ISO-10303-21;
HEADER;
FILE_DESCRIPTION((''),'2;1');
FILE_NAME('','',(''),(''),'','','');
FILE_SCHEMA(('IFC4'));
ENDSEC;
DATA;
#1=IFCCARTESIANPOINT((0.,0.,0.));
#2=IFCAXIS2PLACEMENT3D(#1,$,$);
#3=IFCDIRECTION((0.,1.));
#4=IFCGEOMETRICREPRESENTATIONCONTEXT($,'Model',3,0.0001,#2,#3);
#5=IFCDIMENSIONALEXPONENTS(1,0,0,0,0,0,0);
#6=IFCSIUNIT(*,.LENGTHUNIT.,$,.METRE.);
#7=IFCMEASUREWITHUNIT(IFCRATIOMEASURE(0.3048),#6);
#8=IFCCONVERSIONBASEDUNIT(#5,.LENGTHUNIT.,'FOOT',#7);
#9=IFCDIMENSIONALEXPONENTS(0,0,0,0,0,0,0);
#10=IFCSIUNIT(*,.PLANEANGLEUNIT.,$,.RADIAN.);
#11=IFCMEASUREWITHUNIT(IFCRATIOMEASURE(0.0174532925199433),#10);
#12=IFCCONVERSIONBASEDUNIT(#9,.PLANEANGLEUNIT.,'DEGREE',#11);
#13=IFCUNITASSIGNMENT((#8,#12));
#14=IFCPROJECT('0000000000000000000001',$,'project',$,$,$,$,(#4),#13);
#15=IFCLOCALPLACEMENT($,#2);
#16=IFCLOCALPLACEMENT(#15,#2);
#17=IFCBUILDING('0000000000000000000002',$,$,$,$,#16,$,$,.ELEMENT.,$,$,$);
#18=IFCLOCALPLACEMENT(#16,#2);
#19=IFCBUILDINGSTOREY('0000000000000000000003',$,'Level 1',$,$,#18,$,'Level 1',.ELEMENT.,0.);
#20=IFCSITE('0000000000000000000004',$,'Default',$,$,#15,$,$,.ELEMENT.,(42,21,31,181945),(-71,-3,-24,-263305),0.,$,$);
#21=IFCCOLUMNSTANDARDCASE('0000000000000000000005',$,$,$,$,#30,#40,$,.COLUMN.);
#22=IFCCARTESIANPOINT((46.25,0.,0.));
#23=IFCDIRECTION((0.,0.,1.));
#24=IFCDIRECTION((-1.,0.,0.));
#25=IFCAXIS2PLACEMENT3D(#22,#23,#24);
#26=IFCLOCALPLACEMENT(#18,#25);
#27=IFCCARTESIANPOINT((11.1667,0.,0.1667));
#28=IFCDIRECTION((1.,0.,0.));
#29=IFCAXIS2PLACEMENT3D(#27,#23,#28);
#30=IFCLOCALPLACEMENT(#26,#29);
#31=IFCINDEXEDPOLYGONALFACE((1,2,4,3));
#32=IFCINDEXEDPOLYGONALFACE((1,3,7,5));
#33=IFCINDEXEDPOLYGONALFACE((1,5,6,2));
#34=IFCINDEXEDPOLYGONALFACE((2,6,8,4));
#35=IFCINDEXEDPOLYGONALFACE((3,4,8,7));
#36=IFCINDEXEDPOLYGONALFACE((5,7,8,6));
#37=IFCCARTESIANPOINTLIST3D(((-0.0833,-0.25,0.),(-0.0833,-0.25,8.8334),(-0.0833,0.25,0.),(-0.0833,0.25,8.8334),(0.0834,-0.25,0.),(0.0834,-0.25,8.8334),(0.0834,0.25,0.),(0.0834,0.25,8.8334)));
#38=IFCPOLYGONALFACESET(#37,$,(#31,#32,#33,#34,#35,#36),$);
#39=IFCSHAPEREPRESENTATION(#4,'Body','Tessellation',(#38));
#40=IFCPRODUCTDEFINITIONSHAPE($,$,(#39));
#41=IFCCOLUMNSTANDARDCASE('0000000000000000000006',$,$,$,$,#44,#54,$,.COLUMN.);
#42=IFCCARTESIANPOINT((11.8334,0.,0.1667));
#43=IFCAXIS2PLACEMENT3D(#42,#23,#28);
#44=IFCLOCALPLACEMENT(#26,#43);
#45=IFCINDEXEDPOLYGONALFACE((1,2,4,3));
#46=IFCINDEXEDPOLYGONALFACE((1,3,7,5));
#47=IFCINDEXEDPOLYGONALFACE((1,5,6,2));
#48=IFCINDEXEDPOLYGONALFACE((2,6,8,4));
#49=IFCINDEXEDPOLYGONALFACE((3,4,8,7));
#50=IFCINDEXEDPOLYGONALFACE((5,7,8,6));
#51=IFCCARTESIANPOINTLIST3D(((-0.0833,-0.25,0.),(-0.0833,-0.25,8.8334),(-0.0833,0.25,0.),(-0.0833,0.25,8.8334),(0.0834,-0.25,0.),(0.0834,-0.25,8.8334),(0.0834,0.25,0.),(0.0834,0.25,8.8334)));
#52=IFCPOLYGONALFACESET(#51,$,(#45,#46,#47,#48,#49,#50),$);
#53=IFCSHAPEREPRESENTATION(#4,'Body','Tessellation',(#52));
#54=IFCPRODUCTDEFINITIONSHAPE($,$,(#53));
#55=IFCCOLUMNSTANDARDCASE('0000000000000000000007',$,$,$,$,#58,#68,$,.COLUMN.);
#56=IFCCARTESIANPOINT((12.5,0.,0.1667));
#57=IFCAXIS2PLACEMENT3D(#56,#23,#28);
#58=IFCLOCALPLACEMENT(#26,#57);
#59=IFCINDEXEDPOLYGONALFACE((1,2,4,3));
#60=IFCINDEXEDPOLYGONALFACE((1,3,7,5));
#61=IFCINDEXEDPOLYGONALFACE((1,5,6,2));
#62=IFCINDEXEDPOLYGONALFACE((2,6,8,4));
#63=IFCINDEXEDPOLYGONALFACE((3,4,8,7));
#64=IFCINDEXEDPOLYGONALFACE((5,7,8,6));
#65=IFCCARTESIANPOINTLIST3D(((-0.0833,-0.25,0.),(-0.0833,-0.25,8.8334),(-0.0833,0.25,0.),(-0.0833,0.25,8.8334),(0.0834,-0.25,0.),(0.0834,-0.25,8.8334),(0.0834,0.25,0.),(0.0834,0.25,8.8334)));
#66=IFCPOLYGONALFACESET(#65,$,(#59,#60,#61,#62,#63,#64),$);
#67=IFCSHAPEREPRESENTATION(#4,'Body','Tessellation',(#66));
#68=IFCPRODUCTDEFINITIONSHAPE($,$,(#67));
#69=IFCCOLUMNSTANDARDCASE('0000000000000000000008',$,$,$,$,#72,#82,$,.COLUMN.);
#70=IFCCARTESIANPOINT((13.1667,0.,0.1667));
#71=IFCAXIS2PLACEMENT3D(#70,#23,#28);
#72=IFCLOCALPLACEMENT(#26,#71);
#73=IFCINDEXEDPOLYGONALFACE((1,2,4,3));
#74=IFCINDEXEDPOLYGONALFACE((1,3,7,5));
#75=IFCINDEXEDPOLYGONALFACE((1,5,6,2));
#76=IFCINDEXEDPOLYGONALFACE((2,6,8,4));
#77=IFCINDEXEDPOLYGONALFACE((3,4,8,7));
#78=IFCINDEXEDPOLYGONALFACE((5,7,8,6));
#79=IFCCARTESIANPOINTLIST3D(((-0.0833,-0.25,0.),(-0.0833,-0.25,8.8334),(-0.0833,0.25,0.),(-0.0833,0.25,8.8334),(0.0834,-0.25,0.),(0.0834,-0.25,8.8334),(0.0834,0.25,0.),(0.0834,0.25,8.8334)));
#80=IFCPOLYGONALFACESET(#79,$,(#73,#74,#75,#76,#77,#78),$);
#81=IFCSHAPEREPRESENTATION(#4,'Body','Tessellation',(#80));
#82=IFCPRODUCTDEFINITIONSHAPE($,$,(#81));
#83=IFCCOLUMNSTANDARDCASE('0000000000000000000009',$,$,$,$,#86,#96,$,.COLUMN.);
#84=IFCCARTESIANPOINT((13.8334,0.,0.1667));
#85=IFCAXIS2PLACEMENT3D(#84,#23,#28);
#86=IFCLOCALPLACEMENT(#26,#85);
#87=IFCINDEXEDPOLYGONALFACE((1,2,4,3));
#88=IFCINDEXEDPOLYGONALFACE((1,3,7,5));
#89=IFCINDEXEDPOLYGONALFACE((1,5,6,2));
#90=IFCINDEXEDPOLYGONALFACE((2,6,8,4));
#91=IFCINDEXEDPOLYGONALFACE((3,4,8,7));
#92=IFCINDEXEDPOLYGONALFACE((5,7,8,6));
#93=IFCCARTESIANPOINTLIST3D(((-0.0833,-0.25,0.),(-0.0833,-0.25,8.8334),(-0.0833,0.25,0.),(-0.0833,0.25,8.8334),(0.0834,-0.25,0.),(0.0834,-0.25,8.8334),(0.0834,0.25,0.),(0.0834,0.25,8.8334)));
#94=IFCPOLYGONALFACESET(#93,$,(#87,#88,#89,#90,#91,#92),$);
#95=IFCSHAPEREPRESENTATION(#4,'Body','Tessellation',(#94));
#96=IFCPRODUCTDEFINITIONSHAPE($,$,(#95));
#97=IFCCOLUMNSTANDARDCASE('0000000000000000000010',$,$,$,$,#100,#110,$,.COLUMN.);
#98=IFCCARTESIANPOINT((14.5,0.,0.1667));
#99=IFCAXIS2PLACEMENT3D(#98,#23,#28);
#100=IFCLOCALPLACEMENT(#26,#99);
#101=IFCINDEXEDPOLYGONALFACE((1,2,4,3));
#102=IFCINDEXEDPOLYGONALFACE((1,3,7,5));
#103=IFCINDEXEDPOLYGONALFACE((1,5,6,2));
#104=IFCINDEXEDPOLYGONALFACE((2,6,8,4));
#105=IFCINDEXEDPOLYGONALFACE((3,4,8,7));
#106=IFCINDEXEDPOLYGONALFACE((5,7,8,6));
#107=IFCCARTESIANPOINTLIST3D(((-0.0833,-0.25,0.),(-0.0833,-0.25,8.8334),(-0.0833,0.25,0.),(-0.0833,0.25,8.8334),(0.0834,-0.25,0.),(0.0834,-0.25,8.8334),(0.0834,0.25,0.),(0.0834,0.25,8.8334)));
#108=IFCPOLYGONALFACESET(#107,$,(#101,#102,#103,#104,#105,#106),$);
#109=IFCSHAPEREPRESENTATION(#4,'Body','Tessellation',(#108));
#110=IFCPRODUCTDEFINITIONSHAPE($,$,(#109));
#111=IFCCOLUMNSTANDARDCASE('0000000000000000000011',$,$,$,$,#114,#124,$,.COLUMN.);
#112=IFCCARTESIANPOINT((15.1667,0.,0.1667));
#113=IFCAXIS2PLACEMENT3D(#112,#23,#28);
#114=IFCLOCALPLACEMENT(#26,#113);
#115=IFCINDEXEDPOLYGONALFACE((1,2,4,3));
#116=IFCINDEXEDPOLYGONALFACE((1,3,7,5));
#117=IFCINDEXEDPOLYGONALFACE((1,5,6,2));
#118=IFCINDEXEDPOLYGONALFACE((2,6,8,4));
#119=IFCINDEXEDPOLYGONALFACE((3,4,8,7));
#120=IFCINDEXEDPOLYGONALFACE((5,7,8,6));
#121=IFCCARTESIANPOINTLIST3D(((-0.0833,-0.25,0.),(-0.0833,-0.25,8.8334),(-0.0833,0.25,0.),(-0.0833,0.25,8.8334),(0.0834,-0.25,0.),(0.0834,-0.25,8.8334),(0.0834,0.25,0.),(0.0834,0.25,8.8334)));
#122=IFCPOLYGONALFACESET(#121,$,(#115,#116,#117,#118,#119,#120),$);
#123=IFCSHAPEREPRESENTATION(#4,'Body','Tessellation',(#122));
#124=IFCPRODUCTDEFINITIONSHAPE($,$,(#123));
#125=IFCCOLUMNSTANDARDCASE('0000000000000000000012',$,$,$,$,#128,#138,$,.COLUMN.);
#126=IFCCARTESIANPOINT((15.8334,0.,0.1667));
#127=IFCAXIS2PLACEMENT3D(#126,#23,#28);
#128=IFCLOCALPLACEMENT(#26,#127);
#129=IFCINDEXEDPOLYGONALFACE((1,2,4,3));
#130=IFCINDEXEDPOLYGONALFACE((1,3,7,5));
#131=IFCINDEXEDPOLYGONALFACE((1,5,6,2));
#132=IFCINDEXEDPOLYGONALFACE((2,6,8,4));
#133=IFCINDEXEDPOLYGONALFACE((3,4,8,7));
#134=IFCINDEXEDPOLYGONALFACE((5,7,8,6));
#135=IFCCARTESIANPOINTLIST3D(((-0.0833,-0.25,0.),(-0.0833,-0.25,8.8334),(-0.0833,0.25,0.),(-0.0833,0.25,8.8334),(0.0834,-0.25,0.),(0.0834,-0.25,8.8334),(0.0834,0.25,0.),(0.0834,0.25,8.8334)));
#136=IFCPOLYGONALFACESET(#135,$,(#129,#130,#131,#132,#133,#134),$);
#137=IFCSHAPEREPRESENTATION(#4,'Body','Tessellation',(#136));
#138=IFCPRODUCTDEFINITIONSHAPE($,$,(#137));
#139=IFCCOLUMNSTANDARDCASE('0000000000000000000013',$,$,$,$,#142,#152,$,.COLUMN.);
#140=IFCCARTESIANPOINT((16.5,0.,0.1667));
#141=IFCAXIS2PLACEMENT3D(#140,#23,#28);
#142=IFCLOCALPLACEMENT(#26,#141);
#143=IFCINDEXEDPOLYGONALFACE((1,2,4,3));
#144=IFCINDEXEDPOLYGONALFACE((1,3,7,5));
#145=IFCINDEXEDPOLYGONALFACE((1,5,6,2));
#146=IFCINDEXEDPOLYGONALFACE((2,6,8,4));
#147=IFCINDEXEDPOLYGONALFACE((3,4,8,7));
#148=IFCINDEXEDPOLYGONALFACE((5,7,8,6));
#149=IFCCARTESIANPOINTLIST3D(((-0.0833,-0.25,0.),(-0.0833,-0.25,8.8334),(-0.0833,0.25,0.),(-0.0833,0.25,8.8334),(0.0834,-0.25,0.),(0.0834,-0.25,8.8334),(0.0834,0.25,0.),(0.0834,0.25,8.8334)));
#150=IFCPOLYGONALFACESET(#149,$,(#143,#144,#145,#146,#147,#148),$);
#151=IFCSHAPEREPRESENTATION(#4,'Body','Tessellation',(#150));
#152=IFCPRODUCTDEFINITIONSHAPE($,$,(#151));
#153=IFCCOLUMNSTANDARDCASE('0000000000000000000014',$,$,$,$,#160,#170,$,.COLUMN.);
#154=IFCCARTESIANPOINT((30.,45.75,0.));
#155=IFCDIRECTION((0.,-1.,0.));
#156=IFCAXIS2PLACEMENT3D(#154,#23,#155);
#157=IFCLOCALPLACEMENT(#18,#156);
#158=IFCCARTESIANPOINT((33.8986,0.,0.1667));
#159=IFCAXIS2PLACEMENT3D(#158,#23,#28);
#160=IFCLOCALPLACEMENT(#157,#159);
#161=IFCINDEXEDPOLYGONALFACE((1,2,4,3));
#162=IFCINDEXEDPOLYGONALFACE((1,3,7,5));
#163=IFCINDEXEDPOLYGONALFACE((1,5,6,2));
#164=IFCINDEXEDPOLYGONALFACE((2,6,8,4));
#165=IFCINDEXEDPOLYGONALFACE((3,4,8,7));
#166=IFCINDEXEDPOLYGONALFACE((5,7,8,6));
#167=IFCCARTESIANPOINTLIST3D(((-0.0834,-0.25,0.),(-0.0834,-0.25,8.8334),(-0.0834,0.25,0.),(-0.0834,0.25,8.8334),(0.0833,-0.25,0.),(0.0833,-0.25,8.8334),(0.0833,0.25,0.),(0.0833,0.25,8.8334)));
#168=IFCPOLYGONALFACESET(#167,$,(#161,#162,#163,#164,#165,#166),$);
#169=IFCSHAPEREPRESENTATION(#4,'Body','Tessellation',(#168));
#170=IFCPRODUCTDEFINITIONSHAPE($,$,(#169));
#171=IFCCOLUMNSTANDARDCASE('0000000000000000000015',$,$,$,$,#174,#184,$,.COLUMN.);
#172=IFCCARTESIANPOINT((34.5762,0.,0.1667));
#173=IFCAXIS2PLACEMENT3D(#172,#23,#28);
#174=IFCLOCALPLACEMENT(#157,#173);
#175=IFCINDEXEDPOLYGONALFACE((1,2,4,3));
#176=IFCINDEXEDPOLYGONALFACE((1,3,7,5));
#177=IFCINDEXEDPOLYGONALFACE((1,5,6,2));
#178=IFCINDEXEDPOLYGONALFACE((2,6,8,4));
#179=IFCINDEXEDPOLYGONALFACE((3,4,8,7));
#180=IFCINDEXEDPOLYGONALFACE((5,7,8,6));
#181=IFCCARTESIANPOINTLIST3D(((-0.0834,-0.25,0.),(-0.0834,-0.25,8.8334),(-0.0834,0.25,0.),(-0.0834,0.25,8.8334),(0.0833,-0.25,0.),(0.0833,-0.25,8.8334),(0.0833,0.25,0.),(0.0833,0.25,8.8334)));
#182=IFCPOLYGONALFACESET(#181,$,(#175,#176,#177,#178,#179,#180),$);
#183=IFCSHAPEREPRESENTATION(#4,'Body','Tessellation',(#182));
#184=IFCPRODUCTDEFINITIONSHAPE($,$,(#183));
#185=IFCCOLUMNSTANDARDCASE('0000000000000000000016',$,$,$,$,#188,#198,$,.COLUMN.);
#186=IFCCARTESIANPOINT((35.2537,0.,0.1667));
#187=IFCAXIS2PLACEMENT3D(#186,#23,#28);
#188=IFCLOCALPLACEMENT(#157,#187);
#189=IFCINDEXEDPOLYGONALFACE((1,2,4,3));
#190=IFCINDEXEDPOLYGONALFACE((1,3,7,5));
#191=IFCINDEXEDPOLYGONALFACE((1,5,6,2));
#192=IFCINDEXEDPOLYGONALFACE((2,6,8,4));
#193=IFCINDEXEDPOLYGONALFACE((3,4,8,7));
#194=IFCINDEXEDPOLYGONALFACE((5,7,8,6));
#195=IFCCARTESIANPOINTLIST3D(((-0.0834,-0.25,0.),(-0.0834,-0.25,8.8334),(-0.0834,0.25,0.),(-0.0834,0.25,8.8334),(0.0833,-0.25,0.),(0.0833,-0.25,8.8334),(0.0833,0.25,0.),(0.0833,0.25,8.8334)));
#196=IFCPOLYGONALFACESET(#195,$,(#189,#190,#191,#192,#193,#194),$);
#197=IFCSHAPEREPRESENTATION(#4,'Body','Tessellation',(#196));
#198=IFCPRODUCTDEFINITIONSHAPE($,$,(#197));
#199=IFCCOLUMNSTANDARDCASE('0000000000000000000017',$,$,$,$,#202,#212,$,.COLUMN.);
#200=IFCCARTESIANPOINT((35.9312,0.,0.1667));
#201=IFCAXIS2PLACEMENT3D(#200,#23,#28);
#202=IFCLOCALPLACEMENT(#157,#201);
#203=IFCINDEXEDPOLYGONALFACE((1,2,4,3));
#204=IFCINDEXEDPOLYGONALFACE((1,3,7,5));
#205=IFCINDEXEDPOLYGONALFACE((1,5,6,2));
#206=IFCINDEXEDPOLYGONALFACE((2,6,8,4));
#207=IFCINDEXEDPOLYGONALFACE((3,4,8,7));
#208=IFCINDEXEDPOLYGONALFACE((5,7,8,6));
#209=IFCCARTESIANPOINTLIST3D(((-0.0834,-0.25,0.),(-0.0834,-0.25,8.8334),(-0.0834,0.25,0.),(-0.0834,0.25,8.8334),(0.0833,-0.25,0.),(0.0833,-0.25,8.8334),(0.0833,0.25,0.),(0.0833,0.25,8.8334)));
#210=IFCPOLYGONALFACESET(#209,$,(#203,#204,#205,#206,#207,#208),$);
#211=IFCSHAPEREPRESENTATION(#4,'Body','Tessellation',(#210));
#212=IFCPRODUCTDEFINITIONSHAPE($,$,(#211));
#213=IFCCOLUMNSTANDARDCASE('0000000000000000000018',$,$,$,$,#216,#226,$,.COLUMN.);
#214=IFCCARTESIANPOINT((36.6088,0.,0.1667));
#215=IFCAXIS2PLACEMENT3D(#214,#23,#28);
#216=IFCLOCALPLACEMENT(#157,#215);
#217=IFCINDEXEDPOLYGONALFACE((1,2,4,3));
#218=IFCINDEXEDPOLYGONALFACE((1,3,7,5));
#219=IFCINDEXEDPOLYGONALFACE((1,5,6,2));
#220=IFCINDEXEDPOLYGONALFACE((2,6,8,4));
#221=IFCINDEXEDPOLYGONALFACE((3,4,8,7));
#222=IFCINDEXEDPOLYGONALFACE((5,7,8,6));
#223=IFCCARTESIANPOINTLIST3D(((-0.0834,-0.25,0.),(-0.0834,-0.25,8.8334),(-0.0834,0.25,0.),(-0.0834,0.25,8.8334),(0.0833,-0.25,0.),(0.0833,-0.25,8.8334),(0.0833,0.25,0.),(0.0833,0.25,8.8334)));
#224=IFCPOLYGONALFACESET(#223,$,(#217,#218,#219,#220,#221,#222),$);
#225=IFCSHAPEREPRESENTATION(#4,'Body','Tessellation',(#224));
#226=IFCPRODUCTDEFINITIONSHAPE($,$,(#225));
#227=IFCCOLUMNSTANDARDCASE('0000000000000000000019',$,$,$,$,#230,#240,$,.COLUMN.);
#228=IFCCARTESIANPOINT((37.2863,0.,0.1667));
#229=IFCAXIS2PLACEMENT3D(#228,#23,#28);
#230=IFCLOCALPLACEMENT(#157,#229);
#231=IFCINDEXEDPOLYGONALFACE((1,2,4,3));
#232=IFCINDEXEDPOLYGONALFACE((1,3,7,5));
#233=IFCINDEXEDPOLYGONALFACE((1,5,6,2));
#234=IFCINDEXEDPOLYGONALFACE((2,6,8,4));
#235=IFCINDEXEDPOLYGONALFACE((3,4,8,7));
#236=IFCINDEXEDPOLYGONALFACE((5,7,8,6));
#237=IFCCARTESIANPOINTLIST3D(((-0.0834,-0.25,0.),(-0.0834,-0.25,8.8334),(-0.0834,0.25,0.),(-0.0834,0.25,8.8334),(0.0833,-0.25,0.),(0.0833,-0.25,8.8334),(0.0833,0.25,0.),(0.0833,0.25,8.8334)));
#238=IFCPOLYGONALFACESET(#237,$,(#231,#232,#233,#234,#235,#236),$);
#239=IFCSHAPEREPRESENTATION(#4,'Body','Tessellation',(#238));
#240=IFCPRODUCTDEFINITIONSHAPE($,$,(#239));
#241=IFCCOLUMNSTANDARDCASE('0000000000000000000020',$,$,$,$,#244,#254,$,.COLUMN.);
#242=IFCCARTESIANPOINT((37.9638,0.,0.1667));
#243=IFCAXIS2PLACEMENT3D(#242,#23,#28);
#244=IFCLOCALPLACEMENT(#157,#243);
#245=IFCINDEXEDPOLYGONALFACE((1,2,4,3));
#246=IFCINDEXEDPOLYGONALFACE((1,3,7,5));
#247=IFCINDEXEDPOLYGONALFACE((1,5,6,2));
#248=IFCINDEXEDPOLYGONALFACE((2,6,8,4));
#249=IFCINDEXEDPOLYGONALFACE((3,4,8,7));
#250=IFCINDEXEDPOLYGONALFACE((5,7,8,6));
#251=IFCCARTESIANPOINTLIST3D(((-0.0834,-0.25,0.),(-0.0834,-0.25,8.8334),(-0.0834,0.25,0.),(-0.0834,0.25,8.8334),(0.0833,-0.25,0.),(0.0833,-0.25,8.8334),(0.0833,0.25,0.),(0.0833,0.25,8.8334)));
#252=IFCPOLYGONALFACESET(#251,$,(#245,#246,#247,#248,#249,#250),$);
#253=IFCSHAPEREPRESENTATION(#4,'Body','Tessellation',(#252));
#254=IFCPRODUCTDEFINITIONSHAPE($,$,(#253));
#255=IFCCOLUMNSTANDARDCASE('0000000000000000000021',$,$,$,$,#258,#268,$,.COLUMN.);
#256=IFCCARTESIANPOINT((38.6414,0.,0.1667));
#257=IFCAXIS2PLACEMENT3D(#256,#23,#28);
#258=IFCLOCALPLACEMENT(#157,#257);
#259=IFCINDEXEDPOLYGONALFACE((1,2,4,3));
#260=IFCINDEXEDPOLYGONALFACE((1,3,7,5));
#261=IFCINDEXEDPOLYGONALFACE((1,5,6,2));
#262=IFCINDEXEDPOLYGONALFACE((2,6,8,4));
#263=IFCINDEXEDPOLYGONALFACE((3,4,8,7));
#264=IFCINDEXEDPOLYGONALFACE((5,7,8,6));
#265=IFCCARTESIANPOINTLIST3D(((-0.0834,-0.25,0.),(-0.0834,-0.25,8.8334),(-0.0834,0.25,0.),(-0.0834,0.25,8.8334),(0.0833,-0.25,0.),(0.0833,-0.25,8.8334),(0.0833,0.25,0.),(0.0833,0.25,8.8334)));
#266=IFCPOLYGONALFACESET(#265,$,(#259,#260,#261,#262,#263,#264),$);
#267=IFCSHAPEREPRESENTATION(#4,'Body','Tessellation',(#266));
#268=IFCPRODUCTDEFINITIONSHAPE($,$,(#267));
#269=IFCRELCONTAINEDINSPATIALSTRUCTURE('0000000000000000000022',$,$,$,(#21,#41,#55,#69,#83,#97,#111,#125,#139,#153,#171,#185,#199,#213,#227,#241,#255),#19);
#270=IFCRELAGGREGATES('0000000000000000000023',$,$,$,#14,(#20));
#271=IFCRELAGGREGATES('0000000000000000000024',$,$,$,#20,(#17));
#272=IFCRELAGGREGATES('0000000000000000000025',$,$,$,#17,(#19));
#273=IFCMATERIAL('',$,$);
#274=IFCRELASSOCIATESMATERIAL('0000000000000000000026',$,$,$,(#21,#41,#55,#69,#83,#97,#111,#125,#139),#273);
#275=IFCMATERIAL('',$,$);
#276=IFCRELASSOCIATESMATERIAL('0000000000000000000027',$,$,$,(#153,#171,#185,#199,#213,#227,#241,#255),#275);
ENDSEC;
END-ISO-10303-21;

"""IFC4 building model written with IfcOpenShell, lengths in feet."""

from ifc_helpers import new_model, entity, si_unit, converted_unit, direction, frame, origin, place, context, project, spatial, rectangle, extrude, material, element, save


model = new_model("IFC4")

# Units and contexts
model_context = context("Model", 3, precision=0.0001, world=origin(), true_north=direction((0.0, 1.0)))
ifc_project = project(units=[converted_unit("LENGTHUNIT", "FOOT", entity("IfcRatioMeasure", 0.3048), si_unit("LENGTHUNIT", "METRE"), dimensions=[1, 0, 0, 0, 0, 0, 0]), converted_unit("PLANEANGLEUNIT", "DEGREE", entity("IfcRatioMeasure", 0.0174532925199433), si_unit("PLANEANGLEUNIT", "RADIAN"), dimensions=[0, 0, 0, 0, 0, 0, 0])], contexts=[model_context])

# Site, building, storey
site_placement = place(None, origin())
site = spatial("IfcSite", under=ifc_project, at=site_placement, Name="Default", CompositionType="ELEMENT", RefLatitude=(42, 21, 31, 181945), RefLongitude=(-71, -3, -24, -263305), RefElevation=0.0)
building_placement = place(site_placement, origin())
building = spatial("IfcBuilding", under=site, at=building_placement, CompositionType="ELEMENT")
storey_placement = place(building_placement, origin())
storey = spatial("IfcBuildingStorey", under=building, at=storey_placement, Name="Level 1", LongName="Level 1", CompositionType="ELEMENT", Elevation=0.0)

# Columns
ifc_material_1 = material(Name="")
placement_1 = place(storey_placement, frame((46.25, 0.0, 0.0), z_axis=(0.0, 0.0, 1.0), x_axis=(-1.0, 0.0, 0.0)))
for number, where, z_axis, x_axis in (
    (1, (11.1667, 0.0, 0.1667), (0.0, 0.0, 1.0), (1.0, 0.0, 0.0)),
    (2, (11.8334, 0.0, 0.1667), (0.0, 0.0, 1.0), (1.0, 0.0, 0.0)),
    (3, (12.5, 0.0, 0.1667), (0.0, 0.0, 1.0), (1.0, 0.0, 0.0)),
    (4, (13.1667, 0.0, 0.1667), (0.0, 0.0, 1.0), (1.0, 0.0, 0.0)),
    (5, (13.8334, 0.0, 0.1667), (0.0, 0.0, 1.0), (1.0, 0.0, 0.0)),
    (6, (14.5, 0.0, 0.1667), (0.0, 0.0, 1.0), (1.0, 0.0, 0.0)),
    (7, (15.1667, 0.0, 0.1667), (0.0, 0.0, 1.0), (1.0, 0.0, 0.0)),
    (8, (15.8334, 0.0, 0.1667), (0.0, 0.0, 1.0), (1.0, 0.0, 0.0)),
    (9, (16.5, 0.0, 0.1667), (0.0, 0.0, 1.0), (1.0, 0.0, 0.0)),
):
    element("IfcColumnStandardCase", number, at=place(placement_1, frame(where, z_axis=z_axis, x_axis=x_axis)), inside=storey, material=ifc_material_1, PredefinedType="COLUMN", context=model_context, shape_type="SweptSolid", body=[
        extrude(rectangle(XDim=0.1667, YDim=0.5), origin(), (0.0, 0.0, 1.0), 8.8334),
    ])
ifc_material_2 = material(Name="")
placement_2 = place(storey_placement, frame((30.0, 45.75, 0.0), z_axis=(0.0, 0.0, 1.0), x_axis=(0.0, -1.0, 0.0)))
for number, where, z_axis, x_axis in (
    (10, (33.8986, 0.0, 0.1667), (0.0, 0.0, 1.0), (1.0, 0.0, 0.0)),
    (11, (34.5762, 0.0, 0.1667), (0.0, 0.0, 1.0), (1.0, 0.0, 0.0)),
    (12, (35.2537, 0.0, 0.1667), (0.0, 0.0, 1.0), (1.0, 0.0, 0.0)),
    (13, (35.9312, 0.0, 0.1667), (0.0, 0.0, 1.0), (1.0, 0.0, 0.0)),
    (14, (36.6088, 0.0, 0.1667), (0.0, 0.0, 1.0), (1.0, 0.0, 0.0)),
    (15, (37.2863, 0.0, 0.1667), (0.0, 0.0, 1.0), (1.0, 0.0, 0.0)),
    (16, (37.9638, 0.0, 0.1667), (0.0, 0.0, 1.0), (1.0, 0.0, 0.0)),
    (17, (38.6414, 0.0, 0.1667), (0.0, 0.0, 1.0), (1.0, 0.0, 0.0)),
):
    element("IfcColumnStandardCase", number, at=place(placement_2, frame(where, z_axis=z_axis, x_axis=x_axis)), inside=storey, material=ifc_material_2, PredefinedType="COLUMN", context=model_context, shape_type="SweptSolid", body=[
        extrude(rectangle(XDim=0.1667, YDim=0.5), origin(), (0.0, 0.0, 1.0), 8.8334),
    ])

save(model, "model.ifc")
